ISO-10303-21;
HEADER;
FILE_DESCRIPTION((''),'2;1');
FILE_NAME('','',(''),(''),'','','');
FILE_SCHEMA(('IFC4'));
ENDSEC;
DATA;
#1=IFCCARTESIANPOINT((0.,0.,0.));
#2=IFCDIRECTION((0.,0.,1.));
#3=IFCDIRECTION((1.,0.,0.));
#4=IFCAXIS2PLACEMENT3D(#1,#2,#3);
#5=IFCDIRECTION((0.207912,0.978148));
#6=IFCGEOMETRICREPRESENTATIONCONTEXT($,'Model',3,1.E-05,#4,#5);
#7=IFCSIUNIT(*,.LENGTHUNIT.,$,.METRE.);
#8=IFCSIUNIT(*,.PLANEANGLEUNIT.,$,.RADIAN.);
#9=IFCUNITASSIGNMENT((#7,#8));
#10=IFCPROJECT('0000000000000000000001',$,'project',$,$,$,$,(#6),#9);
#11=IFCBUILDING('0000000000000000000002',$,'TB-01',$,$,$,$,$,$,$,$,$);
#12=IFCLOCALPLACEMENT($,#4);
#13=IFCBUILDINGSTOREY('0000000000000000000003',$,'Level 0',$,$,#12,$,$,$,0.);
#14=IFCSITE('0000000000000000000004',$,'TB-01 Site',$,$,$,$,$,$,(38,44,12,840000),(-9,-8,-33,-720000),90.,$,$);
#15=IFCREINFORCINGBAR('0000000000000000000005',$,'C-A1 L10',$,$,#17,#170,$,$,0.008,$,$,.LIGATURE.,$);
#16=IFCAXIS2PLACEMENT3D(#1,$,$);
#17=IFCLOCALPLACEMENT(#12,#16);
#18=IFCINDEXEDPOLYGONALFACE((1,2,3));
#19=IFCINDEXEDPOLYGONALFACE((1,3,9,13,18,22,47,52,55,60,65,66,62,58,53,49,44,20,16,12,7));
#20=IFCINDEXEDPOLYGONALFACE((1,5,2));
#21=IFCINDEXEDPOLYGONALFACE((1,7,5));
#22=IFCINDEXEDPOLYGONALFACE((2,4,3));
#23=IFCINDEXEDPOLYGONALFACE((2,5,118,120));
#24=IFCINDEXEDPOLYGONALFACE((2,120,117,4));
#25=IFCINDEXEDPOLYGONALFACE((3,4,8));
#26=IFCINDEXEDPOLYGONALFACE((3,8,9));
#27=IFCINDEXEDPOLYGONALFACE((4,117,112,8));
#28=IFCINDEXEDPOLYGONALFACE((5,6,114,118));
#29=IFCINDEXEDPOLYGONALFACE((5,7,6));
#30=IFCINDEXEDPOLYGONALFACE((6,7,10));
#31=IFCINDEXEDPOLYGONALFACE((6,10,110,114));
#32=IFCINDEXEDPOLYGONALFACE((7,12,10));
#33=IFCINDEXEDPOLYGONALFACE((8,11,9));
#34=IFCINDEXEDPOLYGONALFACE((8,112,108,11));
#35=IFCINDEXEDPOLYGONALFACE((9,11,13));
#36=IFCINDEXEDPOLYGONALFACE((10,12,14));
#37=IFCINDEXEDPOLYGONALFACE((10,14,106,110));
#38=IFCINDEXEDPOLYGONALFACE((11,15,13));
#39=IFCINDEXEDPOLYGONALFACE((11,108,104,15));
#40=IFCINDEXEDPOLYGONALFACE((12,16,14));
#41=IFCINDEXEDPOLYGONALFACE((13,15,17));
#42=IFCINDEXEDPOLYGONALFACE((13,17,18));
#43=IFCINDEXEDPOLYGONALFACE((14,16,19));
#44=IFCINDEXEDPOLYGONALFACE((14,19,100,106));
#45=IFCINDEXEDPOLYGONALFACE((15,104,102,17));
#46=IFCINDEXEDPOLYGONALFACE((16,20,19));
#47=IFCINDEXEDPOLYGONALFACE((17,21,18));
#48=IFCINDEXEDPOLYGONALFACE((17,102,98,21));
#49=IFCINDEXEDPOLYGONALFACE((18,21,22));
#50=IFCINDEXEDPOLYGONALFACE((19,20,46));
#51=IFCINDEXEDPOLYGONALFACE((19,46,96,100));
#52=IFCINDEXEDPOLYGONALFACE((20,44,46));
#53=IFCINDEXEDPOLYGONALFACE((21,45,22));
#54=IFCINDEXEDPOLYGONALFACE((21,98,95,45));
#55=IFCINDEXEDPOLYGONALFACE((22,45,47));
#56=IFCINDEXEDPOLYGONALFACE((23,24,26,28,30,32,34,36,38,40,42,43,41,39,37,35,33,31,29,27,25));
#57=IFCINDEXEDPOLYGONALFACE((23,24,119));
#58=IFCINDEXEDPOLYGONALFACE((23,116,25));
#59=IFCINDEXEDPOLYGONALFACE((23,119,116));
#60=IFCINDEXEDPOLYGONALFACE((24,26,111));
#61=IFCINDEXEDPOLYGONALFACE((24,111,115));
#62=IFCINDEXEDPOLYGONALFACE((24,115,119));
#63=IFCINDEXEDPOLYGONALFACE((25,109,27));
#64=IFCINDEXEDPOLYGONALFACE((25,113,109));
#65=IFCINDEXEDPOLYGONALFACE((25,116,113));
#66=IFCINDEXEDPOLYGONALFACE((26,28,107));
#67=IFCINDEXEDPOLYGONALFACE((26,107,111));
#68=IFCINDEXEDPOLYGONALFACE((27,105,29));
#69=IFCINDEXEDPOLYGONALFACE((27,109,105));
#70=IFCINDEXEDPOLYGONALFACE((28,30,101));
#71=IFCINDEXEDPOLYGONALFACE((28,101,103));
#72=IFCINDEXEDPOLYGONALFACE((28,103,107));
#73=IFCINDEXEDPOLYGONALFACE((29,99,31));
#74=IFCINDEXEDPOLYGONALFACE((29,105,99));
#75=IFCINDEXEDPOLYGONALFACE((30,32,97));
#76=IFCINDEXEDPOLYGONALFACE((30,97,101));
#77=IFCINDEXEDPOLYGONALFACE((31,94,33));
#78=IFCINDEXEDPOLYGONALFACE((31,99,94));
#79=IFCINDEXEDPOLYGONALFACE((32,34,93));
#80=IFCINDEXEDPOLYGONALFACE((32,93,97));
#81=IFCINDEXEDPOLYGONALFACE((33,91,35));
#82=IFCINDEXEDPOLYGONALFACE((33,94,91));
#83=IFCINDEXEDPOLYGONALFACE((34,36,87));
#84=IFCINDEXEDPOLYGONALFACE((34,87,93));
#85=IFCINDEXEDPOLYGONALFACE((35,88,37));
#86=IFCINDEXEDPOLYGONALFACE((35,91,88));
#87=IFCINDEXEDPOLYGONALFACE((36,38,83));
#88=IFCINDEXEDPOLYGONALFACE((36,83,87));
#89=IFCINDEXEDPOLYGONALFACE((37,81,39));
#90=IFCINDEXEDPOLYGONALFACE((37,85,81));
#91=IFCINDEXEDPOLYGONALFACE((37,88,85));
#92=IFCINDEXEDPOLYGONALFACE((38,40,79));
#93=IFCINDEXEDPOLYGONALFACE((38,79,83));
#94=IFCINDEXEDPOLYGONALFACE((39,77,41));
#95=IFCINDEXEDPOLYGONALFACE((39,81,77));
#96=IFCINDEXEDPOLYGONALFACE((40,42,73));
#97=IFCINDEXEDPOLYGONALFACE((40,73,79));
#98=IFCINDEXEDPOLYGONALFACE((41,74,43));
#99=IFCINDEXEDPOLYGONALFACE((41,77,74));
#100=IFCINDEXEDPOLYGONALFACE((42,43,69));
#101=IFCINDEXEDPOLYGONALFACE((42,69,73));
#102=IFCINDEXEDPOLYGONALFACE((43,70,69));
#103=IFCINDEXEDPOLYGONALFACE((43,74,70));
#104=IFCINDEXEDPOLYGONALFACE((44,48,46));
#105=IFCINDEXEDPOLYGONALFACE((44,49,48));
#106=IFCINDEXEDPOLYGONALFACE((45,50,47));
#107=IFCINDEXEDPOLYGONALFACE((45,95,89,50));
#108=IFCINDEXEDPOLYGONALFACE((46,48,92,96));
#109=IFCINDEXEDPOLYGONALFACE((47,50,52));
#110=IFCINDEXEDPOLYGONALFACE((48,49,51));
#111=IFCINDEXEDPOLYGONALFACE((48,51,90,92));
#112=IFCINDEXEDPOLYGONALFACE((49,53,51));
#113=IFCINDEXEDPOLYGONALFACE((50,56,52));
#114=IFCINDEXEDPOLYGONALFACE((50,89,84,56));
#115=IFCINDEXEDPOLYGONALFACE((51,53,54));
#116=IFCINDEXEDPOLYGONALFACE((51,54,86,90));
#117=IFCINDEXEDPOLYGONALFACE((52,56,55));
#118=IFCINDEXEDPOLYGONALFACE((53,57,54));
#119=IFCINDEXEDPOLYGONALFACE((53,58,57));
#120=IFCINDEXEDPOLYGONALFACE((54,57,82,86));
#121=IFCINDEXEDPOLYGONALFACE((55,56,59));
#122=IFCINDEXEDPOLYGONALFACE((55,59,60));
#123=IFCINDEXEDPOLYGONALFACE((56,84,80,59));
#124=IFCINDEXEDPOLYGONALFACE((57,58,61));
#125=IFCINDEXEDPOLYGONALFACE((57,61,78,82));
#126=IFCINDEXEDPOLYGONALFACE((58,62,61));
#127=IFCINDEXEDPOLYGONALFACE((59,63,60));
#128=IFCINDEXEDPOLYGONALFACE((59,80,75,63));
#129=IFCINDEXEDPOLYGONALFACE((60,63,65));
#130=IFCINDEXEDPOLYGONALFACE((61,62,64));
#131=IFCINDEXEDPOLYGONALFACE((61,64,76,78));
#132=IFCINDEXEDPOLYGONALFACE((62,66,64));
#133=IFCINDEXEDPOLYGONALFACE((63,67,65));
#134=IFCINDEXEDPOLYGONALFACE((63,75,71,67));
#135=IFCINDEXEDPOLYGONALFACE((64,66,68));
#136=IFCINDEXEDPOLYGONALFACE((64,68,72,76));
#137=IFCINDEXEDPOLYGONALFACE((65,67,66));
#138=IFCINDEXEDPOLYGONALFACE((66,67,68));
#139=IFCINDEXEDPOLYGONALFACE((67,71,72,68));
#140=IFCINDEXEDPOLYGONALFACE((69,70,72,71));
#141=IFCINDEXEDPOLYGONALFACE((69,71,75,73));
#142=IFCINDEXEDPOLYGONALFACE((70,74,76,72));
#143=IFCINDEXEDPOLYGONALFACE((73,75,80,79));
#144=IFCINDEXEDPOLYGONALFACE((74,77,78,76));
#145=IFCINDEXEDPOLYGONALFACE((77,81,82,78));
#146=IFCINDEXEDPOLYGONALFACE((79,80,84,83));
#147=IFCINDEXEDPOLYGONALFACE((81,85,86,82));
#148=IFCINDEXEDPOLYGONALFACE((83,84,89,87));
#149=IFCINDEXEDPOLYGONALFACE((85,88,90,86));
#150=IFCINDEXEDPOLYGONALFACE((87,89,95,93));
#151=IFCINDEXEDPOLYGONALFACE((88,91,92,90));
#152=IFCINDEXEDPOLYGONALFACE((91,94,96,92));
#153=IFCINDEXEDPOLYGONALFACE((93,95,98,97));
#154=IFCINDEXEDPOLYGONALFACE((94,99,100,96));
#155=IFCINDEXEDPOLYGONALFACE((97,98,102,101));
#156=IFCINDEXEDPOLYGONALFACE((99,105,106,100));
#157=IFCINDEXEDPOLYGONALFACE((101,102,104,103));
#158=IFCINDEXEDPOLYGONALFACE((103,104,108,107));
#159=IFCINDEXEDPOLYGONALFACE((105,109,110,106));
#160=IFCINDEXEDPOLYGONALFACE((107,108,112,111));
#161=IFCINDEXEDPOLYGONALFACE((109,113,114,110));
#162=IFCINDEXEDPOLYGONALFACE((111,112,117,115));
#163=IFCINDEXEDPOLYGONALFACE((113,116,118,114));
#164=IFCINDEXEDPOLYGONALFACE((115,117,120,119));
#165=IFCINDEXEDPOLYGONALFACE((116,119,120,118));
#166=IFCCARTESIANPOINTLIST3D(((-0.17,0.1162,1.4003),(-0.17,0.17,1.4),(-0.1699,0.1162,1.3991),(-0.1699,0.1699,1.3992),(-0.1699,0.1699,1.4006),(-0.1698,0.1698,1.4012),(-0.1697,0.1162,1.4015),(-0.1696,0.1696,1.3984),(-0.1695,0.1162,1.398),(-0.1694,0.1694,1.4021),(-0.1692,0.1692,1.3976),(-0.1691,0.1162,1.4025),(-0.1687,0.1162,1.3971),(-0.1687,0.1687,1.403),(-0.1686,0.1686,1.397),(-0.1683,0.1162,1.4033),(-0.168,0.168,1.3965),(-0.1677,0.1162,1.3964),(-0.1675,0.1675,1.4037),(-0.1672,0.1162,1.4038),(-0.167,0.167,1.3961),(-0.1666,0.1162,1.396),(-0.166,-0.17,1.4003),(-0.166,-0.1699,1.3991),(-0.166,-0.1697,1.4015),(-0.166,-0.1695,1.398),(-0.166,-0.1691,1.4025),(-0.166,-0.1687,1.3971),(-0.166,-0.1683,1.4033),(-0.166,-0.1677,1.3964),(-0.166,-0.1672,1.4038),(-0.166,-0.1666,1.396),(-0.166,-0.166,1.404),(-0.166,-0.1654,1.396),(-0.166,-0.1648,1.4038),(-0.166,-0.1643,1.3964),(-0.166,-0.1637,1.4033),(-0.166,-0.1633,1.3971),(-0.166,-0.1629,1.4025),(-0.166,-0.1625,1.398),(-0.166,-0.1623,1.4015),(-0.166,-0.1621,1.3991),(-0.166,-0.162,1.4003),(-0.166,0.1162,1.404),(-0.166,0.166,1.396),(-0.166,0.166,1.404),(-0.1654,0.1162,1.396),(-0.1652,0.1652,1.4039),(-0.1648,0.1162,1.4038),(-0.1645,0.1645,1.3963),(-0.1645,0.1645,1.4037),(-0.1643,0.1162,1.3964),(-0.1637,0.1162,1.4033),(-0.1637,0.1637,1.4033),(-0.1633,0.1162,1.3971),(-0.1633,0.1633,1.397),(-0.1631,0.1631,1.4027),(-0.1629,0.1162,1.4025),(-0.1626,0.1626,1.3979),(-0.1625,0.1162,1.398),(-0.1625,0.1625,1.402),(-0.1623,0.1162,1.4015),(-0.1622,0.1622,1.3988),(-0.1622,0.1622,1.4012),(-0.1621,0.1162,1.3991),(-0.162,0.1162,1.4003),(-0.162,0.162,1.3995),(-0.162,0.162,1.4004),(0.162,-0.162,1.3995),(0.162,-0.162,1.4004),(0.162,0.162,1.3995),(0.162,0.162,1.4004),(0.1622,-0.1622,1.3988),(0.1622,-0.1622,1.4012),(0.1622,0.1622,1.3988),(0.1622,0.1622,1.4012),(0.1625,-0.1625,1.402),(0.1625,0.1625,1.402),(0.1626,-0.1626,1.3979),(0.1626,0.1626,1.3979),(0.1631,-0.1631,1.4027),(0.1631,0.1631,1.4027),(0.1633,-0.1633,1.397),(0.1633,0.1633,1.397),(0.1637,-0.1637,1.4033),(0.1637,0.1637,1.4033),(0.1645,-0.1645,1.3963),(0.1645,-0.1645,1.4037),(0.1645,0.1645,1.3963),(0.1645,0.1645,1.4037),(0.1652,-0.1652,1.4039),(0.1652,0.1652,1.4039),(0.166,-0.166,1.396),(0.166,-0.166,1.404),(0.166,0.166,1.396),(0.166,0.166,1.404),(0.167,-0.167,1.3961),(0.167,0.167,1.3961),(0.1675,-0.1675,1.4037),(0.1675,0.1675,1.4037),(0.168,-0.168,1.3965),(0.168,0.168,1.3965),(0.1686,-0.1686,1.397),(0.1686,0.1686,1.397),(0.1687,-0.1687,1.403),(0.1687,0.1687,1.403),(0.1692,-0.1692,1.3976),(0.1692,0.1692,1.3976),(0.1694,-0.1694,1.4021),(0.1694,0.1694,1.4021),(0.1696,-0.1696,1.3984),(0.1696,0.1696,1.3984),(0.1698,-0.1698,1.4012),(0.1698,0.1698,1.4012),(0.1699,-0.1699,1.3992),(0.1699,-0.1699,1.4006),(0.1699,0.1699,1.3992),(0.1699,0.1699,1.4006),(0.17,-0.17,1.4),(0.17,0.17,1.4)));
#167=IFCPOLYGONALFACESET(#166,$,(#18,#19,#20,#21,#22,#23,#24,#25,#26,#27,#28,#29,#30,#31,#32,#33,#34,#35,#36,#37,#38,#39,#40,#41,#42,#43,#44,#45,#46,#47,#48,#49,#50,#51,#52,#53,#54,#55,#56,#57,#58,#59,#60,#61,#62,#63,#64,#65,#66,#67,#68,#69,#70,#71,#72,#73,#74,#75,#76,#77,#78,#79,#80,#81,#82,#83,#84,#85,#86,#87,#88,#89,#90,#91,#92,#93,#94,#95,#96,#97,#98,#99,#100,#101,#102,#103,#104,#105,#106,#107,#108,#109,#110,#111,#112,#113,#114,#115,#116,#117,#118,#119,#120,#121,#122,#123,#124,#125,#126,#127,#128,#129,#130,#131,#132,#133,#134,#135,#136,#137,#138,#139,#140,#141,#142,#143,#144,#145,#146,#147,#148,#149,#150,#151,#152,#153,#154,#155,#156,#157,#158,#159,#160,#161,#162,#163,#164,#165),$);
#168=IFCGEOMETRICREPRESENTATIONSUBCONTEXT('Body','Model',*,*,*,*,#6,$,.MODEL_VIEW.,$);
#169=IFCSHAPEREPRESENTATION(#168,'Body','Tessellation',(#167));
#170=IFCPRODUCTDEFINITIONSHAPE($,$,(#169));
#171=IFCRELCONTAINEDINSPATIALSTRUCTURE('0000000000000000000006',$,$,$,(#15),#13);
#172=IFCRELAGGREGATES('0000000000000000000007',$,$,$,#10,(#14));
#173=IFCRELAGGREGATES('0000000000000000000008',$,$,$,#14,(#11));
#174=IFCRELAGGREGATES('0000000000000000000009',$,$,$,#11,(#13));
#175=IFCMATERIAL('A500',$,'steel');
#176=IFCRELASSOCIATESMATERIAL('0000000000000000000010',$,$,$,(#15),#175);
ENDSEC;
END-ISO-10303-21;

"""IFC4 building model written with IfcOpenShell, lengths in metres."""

from ifc_helpers import new_model, entity, si_unit, direction, origin_with_axes, place, context, subcontext, project, spatial, material, element, save


model = new_model("IFC4")

# Units and contexts
model_context = context("Model", 3, precision=1e-05, world=origin_with_axes(), true_north=direction((0.207912, 0.978148)))
body_context = subcontext(model_context, "Body", "Model", "MODEL_VIEW")
ifc_project = project(units=[si_unit("LENGTHUNIT", "METRE"), si_unit("PLANEANGLEUNIT", "RADIAN")], contexts=[model_context])

# Site, building, storey
site = spatial("IfcSite", under=ifc_project, Name="TB-01 Site", RefLatitude=(38, 44, 12, 840000), RefLongitude=(-9, -8, -33, -720000), RefElevation=90.0)
building = spatial("IfcBuilding", under=site, Name="TB-01")
storey_placement = place(None, origin_with_axes())
storey = spatial("IfcBuildingStorey", under=building, at=storey_placement, Name="Level 0", Elevation=0.0)

# Reinforcing bar
ifc_material_1 = material(Name="A500", Category="steel")
reinforcing_bar_1_placement = place(storey_placement, origin_with_axes())
element("IfcReinforcingBar", 1, at=reinforcing_bar_1_placement, inside=storey, material=ifc_material_1, Name="C-A1 L10", NominalDiameter=0.008, PredefinedType="LIGATURE", context=body_context, shape_type="AdvancedSweptSolid", body=[
    entity("IfcSweptDiskSolid", entity("IfcPolyline", [entity("IfcCartesianPoint", [-0.166, -0.166, 1.4]), entity("IfcCartesianPoint", [0.166, -0.166, 1.4]), entity("IfcCartesianPoint", [0.166, 0.166, 1.4]), entity("IfcCartesianPoint", [-0.166, 0.166, 1.4]), entity("IfcCartesianPoint", [-0.166, 0.1162, 1.4])]), 0.004),
])

save(model, "model.ifc")
